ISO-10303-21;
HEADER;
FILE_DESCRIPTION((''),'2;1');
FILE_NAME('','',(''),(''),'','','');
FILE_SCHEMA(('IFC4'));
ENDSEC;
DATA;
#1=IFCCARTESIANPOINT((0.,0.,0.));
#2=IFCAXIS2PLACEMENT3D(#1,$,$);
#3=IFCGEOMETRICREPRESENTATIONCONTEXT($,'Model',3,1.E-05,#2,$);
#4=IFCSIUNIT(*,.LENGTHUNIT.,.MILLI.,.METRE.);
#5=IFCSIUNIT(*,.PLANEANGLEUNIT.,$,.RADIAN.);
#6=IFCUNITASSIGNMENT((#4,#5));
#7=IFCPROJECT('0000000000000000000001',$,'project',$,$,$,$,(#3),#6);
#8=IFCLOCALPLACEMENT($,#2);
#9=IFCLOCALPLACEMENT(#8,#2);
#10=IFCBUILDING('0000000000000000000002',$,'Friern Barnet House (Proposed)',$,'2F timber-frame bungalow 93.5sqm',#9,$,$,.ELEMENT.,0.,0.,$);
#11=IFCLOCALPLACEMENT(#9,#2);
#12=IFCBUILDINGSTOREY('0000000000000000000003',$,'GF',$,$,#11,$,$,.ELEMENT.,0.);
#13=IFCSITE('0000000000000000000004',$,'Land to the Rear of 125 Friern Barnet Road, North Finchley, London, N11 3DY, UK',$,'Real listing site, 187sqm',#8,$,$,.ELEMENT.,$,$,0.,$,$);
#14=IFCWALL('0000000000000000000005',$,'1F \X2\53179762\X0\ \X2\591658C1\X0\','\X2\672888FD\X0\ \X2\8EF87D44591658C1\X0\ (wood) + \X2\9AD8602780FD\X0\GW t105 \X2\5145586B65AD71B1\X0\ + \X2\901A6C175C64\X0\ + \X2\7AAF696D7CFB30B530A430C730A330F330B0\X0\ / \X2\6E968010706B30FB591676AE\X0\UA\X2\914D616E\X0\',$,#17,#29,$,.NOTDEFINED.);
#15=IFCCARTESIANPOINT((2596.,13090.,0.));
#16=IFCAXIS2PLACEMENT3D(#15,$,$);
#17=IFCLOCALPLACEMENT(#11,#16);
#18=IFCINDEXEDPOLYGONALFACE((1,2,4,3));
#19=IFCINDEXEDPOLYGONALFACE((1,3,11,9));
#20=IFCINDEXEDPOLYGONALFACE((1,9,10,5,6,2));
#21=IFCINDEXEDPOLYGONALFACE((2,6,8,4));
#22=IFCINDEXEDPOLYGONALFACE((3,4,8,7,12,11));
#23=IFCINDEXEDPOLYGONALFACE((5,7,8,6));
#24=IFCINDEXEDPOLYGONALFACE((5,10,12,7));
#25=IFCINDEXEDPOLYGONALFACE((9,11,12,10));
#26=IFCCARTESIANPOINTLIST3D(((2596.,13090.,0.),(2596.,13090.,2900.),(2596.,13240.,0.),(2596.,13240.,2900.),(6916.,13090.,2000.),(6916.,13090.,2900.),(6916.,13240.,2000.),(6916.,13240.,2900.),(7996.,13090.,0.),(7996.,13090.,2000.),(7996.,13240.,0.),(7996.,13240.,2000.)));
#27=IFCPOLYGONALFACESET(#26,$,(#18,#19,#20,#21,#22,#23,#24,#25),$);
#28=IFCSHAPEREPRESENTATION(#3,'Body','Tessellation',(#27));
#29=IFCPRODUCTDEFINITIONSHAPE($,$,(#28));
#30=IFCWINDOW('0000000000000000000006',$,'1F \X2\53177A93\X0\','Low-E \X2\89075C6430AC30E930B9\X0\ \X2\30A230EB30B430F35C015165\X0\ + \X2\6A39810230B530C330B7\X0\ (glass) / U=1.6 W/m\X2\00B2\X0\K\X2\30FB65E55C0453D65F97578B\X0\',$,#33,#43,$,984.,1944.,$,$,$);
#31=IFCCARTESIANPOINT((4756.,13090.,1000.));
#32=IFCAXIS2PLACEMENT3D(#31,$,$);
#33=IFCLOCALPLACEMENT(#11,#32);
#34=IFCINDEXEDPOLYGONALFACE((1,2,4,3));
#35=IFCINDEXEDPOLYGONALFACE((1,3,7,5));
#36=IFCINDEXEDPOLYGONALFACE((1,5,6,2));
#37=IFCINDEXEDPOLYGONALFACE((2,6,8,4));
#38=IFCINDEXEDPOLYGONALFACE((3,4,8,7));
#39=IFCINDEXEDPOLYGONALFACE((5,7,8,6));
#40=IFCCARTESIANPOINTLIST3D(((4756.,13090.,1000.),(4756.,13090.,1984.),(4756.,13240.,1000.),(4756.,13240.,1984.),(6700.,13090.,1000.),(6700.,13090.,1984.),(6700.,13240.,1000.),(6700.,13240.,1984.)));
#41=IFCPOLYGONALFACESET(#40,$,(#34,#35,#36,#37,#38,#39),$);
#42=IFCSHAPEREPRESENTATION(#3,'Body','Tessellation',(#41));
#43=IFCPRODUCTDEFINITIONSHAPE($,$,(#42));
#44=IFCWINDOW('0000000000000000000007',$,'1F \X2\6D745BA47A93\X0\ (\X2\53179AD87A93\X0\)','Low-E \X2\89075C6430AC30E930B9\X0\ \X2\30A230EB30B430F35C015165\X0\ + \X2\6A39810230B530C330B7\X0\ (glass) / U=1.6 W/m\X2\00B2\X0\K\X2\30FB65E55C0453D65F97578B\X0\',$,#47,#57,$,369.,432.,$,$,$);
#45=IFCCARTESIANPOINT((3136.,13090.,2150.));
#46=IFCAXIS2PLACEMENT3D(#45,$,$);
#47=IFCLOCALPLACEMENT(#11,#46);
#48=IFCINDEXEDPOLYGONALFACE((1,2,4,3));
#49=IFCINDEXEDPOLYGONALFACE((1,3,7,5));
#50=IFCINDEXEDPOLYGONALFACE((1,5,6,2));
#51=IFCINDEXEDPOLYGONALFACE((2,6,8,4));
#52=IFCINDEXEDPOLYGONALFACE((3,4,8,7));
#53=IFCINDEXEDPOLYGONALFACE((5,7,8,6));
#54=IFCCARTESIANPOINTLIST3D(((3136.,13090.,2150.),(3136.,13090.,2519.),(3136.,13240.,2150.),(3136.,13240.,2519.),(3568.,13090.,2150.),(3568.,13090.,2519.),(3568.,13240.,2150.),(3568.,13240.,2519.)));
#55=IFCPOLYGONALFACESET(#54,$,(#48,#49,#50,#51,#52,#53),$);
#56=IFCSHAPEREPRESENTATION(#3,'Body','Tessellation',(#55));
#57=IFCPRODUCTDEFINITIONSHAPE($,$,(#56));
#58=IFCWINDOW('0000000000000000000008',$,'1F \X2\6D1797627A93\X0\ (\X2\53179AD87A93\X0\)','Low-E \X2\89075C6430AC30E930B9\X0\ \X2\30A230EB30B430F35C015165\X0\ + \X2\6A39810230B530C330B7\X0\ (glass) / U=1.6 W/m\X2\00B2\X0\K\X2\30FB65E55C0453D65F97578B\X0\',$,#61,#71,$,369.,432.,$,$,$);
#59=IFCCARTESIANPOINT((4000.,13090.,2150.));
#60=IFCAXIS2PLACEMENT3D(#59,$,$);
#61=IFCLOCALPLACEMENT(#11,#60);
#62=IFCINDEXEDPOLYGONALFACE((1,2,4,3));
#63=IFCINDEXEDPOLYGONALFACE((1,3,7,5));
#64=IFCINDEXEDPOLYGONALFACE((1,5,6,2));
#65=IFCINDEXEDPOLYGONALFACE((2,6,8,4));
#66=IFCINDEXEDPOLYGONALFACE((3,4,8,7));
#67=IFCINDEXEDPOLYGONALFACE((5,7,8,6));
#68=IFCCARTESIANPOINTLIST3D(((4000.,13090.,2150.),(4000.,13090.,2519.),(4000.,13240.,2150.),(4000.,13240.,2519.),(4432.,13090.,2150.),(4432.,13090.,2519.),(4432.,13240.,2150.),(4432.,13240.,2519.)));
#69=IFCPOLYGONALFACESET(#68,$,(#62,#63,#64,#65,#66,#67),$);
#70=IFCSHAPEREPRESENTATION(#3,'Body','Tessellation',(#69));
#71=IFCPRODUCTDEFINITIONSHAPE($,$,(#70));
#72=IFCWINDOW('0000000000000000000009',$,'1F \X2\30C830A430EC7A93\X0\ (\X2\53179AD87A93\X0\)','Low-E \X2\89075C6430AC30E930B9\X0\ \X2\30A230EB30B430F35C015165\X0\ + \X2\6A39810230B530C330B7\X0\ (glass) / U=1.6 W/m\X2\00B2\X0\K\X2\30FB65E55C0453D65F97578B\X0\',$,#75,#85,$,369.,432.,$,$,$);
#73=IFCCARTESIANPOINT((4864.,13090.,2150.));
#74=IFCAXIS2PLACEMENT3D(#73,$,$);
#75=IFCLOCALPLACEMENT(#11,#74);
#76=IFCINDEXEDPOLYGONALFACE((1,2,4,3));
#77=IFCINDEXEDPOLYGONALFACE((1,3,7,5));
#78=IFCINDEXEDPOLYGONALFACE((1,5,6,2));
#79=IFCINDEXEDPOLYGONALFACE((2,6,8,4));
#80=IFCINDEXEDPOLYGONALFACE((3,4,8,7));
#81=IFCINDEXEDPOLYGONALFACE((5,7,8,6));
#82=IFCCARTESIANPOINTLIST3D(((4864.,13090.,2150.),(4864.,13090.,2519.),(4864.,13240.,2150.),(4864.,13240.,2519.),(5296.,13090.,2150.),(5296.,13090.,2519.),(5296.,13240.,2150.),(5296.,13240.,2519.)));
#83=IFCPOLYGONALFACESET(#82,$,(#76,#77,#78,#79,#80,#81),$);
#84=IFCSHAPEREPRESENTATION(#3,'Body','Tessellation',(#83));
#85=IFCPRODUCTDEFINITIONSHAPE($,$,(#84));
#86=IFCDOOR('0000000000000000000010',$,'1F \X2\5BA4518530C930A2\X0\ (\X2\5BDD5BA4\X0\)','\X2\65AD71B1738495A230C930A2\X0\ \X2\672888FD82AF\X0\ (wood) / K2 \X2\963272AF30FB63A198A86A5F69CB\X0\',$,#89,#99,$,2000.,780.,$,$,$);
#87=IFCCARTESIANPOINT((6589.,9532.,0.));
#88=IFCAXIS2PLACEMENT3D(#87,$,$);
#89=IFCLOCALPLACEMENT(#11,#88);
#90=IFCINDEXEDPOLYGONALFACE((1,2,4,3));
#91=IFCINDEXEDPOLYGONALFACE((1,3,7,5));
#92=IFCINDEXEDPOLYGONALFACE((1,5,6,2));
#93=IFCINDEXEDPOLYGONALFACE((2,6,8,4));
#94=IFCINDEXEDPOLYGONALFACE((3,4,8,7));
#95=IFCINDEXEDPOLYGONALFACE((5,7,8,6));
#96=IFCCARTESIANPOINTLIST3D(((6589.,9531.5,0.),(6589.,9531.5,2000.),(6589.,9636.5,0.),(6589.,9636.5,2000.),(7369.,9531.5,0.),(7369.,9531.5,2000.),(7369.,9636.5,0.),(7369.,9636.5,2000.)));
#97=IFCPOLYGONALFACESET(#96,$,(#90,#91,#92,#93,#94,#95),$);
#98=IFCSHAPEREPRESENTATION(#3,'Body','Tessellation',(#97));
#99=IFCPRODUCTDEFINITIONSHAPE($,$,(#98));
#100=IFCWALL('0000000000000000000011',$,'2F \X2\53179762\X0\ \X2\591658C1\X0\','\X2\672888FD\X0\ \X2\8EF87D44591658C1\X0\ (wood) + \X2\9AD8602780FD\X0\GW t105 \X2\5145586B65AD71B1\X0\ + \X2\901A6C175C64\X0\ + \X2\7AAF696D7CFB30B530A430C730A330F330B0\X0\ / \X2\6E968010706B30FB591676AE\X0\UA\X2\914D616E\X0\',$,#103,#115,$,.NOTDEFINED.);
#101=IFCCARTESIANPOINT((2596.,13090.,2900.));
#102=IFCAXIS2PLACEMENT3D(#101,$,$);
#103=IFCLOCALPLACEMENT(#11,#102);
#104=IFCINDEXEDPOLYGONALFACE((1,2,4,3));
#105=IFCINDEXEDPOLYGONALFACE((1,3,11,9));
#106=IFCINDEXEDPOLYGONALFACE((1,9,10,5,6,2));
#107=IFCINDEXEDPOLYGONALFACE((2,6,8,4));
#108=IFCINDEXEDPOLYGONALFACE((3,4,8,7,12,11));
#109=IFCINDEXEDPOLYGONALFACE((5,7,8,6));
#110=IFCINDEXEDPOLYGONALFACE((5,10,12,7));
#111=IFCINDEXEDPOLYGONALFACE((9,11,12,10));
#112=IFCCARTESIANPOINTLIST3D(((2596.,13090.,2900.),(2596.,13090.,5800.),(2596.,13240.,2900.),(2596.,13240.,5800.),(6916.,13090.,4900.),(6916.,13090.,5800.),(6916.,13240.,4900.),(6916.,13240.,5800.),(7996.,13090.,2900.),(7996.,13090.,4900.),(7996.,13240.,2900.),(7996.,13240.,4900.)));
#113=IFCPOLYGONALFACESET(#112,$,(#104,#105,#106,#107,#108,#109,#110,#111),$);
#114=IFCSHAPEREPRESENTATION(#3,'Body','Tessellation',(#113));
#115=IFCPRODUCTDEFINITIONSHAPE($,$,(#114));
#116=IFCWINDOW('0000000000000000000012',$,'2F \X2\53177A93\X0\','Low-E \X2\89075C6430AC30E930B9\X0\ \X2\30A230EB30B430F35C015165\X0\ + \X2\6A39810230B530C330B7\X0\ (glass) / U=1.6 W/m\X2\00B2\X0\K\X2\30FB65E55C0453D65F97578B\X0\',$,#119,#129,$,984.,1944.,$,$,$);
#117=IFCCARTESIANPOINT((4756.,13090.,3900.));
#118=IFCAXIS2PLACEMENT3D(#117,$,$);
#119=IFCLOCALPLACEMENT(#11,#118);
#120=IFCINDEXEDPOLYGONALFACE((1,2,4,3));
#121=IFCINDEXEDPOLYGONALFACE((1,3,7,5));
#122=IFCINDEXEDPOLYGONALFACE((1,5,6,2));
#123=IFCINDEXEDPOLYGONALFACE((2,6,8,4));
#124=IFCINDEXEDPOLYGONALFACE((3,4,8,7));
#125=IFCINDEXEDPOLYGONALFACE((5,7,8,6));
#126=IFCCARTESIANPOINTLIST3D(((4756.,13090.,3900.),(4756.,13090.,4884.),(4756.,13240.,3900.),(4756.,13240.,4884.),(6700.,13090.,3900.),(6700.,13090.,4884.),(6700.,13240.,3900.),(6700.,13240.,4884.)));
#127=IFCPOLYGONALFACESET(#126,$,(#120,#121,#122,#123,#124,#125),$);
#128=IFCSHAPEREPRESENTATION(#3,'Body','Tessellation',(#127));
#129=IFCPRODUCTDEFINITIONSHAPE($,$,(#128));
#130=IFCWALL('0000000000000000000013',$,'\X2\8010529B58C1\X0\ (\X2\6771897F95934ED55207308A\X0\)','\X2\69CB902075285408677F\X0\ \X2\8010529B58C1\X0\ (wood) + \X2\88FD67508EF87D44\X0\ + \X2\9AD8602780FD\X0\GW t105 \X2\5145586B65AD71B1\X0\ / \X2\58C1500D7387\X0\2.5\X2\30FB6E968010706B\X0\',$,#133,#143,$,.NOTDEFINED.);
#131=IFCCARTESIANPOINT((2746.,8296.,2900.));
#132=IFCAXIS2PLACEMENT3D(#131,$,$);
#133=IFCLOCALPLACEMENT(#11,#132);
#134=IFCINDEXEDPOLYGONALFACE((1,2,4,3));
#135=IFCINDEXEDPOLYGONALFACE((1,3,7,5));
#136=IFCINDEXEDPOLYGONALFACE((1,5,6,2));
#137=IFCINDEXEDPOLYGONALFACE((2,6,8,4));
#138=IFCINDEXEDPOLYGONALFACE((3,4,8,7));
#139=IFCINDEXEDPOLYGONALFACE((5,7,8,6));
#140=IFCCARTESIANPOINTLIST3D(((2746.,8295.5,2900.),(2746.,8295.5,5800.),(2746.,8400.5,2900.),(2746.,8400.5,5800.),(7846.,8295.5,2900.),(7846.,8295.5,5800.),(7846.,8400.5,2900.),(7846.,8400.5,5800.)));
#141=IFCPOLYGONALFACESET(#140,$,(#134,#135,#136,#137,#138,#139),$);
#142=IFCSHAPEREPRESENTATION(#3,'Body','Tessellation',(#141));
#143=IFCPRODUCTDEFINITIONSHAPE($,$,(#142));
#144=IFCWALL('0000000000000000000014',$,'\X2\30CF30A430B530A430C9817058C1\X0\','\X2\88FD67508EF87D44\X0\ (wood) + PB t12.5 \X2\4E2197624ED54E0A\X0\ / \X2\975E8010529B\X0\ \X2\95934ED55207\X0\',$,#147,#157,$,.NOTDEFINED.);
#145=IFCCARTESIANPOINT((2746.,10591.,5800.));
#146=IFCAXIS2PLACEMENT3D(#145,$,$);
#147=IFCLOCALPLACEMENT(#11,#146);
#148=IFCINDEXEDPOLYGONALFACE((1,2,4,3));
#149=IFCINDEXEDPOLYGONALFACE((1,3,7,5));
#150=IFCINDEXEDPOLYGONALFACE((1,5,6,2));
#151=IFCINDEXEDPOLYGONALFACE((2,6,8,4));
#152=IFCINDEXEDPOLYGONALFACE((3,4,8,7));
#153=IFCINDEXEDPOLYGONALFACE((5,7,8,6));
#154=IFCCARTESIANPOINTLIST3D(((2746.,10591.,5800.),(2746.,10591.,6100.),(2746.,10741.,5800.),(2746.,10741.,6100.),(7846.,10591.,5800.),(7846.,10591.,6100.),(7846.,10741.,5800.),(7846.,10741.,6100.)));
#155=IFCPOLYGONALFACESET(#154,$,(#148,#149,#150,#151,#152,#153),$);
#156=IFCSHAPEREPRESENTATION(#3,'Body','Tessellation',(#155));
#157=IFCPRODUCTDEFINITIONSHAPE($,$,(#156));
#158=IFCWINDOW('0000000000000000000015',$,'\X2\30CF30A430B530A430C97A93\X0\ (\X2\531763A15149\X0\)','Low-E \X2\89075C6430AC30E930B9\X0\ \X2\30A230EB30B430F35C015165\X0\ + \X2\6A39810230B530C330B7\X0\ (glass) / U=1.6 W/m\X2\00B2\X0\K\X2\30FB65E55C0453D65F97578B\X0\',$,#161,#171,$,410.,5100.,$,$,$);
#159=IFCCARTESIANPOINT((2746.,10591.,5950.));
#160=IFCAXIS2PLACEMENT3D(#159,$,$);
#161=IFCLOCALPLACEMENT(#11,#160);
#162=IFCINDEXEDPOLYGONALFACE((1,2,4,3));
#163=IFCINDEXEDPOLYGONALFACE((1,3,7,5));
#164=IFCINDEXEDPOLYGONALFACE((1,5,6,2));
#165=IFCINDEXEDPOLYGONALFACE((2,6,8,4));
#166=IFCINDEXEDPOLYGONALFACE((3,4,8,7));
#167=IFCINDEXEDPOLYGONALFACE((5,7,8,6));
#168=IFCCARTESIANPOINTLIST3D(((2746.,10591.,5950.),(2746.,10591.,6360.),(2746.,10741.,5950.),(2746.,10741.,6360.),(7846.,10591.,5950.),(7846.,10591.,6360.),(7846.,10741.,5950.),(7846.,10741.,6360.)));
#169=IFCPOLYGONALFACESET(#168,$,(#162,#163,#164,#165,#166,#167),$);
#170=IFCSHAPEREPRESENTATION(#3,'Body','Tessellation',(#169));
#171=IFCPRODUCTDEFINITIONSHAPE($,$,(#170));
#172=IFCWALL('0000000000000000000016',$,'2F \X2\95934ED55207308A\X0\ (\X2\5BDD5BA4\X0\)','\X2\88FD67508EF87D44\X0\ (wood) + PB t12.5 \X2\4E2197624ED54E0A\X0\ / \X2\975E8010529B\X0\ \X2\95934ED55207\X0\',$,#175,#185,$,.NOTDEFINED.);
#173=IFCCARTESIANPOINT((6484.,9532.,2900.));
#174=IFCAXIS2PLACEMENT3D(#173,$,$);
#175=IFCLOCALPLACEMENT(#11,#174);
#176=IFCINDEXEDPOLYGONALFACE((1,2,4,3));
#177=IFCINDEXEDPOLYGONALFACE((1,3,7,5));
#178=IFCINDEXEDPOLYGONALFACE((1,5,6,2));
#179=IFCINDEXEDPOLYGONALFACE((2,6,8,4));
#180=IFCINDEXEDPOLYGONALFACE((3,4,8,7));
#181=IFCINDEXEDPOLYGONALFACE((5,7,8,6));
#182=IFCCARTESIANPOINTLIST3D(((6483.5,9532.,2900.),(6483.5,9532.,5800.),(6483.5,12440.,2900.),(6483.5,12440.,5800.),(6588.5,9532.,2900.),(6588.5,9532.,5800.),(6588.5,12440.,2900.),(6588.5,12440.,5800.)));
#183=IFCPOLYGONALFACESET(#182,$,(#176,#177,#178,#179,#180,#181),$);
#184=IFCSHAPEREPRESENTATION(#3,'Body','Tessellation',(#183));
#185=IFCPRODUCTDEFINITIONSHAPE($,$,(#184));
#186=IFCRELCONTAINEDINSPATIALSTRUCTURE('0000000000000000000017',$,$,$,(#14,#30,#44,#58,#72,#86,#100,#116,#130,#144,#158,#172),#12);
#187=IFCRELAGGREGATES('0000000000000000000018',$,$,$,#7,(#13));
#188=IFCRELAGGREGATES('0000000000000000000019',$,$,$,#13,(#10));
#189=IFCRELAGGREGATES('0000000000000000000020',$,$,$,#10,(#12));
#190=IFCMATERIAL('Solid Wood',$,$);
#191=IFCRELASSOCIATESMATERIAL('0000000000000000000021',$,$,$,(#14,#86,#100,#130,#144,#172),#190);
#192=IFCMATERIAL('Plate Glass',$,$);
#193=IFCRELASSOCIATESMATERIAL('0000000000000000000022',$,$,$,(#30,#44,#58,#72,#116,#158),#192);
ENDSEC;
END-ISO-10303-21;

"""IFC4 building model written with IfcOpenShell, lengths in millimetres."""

from ifc_helpers import new_model, si_unit, frame, frame_2d, origin, place, context, project, spatial, rectangle, extrude, material, element, fill, save


model = new_model("IFC4")

# Units and contexts
model_context = context("Model", 3, precision=1e-05, world=origin())
ifc_project = project(units=[si_unit("LENGTHUNIT", "METRE", prefix="MILLI"), si_unit("PLANEANGLEUNIT", "RADIAN")], contexts=[model_context])

# Site, building, storey
site_placement = place(None, origin())
site = spatial("IfcSite", under=ifc_project, at=site_placement, Name="Land to the Rear of 125 Friern Barnet Road, North Finchley, London, N11 3DY, UK", ObjectType="Real listing site, 187sqm", CompositionType="ELEMENT", RefElevation=0.0)
building_placement = place(site_placement, origin())
building = spatial("IfcBuilding", under=site, at=building_placement, Name="Friern Barnet House (Proposed)", ObjectType="2F timber-frame bungalow 93.5sqm", CompositionType="ELEMENT", ElevationOfRefHeight=0.0, ElevationOfTerrain=0.0)
storey_placement = place(building_placement, origin())
storey = spatial("IfcBuildingStorey", under=building, at=storey_placement, Name="GF", CompositionType="ELEMENT", Elevation=0.0)

# Wall, openings, windows
ifc_material_1 = material(Name="Solid Wood")
wall_1_placement = place(storey_placement, frame((2596.0, 13090.0, 0.0)))
wall_1 = element("IfcWall", 1, at=wall_1_placement, inside=storey, material=ifc_material_1, Name="1F 北面 外壁", Description="木製 軸組外壁 (wood) + 高性能GW t105 充填断熱 + 通気層 + 窯業系サイディング / 準耐火・外皮UA配慮", PredefinedType="NOTDEFINED", context=model_context, shape_type="SweptSolid", body=[
    extrude(rectangle(XDim=5400.0, YDim=150.0, at=frame_2d((2700.0, 75.0))), frame((2596.0, 13090.0, 0.0)), (0.0, 0.0, 1.0), 2900.0),
])
opening_1_placement = place(storey_placement, frame((4756.0, 13090.0, 1000.0)))
opening_1 = element("IfcOpeningElement", 2, at=opening_1_placement, cuts=wall_1, PredefinedType="NOTDEFINED", context=model_context, shape_type="SweptSolid", body=[
    extrude(rectangle(XDim=1944.0, YDim=150.0, at=frame_2d((972.0, 75.0))), frame((4756.0, 13090.0, 1000.0)), (0.0, 0.0, 1.0), 984.0),
])
opening_2_placement = place(storey_placement, frame((3136.0, 13090.0, 2150.0)))
opening_2 = element("IfcOpeningElement", 3, at=opening_2_placement, cuts=wall_1, PredefinedType="NOTDEFINED", context=model_context, shape_type="SweptSolid", body=[
    extrude(rectangle(XDim=432.0, YDim=150.0, at=frame_2d((216.0, 75.0))), frame((3136.0, 13090.0, 2150.0)), (0.0, 0.0, 1.0), 369.0),
])
opening_3_placement = place(storey_placement, frame((4000.0, 13090.0, 2150.0)))
opening_3 = element("IfcOpeningElement", 4, at=opening_3_placement, cuts=wall_1, PredefinedType="NOTDEFINED", context=model_context, shape_type="SweptSolid", body=[
    extrude(rectangle(XDim=432.0, YDim=150.0, at=frame_2d((216.0, 75.0))), frame((4000.0, 13090.0, 2150.0)), (0.0, 0.0, 1.0), 369.0),
])
opening_4_placement = place(storey_placement, frame((4864.0, 13090.0, 2150.0)))
opening_4 = element("IfcOpeningElement", 5, at=opening_4_placement, cuts=wall_1, PredefinedType="NOTDEFINED", context=model_context, shape_type="SweptSolid", body=[
    extrude(rectangle(XDim=432.0, YDim=150.0, at=frame_2d((216.0, 75.0))), frame((4864.0, 13090.0, 2150.0)), (0.0, 0.0, 1.0), 369.0),
])
ifc_material_2 = material(Name="Plate Glass")
window_1_placement = place(storey_placement, frame((4756.0, 13090.0, 1000.0)))
window_1 = element("IfcWindow", 6, at=window_1_placement, inside=storey, material=ifc_material_2, Name="1F 北窓", Description="Low-E 複層ガラス アルゴン封入 + 樹脂サッシ (glass) / U=1.6 W/m²K・日射取得型", OverallHeight=984.0, OverallWidth=1944.0, context=model_context, shape_type="SweptSolid", body=[
    extrude(rectangle(XDim=1944.0, YDim=150.0, at=frame_2d((972.0, 75.0))), frame((4756.0, 13090.0, 1000.0)), (0.0, 0.0, 1.0), 984.0),
])
fill(opening_1, window_1)
window_2_placement = place(storey_placement, frame((3136.0, 13090.0, 2150.0)))
window_2 = element("IfcWindow", 7, at=window_2_placement, inside=storey, material=ifc_material_2, Name="1F 浴室窓 (北高窓)", Description="Low-E 複層ガラス アルゴン封入 + 樹脂サッシ (glass) / U=1.6 W/m²K・日射取得型", OverallHeight=369.0, OverallWidth=432.0, context=model_context, shape_type="SweptSolid", body=[
    extrude(rectangle(XDim=432.0, YDim=150.0, at=frame_2d((216.0, 75.0))), frame((3136.0, 13090.0, 2150.0)), (0.0, 0.0, 1.0), 369.0),
])
fill(opening_2, window_2)
window_3_placement = place(storey_placement, frame((4000.0, 13090.0, 2150.0)))
window_3 = element("IfcWindow", 8, at=window_3_placement, inside=storey, material=ifc_material_2, Name="1F 洗面窓 (北高窓)", Description="Low-E 複層ガラス アルゴン封入 + 樹脂サッシ (glass) / U=1.6 W/m²K・日射取得型", OverallHeight=369.0, OverallWidth=432.0, context=model_context, shape_type="SweptSolid", body=[
    extrude(rectangle(XDim=432.0, YDim=150.0, at=frame_2d((216.0, 75.0))), frame((4000.0, 13090.0, 2150.0)), (0.0, 0.0, 1.0), 369.0),
])
fill(opening_3, window_3)
window_4_placement = place(storey_placement, frame((4864.0, 13090.0, 2150.0)))
window_4 = element("IfcWindow", 9, at=window_4_placement, inside=storey, material=ifc_material_2, Name="1F トイレ窓 (北高窓)", Description="Low-E 複層ガラス アルゴン封入 + 樹脂サッシ (glass) / U=1.6 W/m²K・日射取得型", OverallHeight=369.0, OverallWidth=432.0, context=model_context, shape_type="SweptSolid", body=[
    extrude(rectangle(XDim=432.0, YDim=150.0, at=frame_2d((216.0, 75.0))), frame((4864.0, 13090.0, 2150.0)), (0.0, 0.0, 1.0), 369.0),
])
fill(opening_4, window_4)

# Door
door_1_placement = place(storey_placement, frame((6589.0, 9532.0, 0.0)))
element("IfcDoor", 10, at=door_1_placement, inside=storey, material=ifc_material_1, Name="1F 室内ドア (寝室)", Description="断熱玄関ドア 木製芯 (wood) / K2 防犯・採風機構", OverallHeight=2000.0, OverallWidth=780.0, context=model_context, shape_type="SweptSolid", body=[
    extrude(rectangle(XDim=780.0, YDim=105.0, at=frame_2d((390.0, 52.0))), frame((6589.0, 9532.0, 0.0)), (0.0, 0.0, 1.0), 2000.0),
])

# Wall, opening, window
wall_2_placement = place(storey_placement, frame((2596.0, 13090.0, 2900.0)))
wall_2 = element("IfcWall", 11, at=wall_2_placement, inside=storey, material=ifc_material_1, Name="2F 北面 外壁", Description="木製 軸組外壁 (wood) + 高性能GW t105 充填断熱 + 通気層 + 窯業系サイディング / 準耐火・外皮UA配慮", PredefinedType="NOTDEFINED", context=model_context, shape_type="SweptSolid", body=[
    extrude(rectangle(XDim=5400.0, YDim=150.0, at=frame_2d((2700.0, 75.0))), frame((2596.0, 13090.0, 2900.0)), (0.0, 0.0, 1.0), 2900.0),
])
opening_5_placement = place(storey_placement, frame((4756.0, 13090.0, 3900.0)))
opening_5 = element("IfcOpeningElement", 12, at=opening_5_placement, cuts=wall_2, PredefinedType="NOTDEFINED", context=model_context, shape_type="SweptSolid", body=[
    extrude(rectangle(XDim=1944.0, YDim=150.0, at=frame_2d((972.0, 75.0))), frame((4756.0, 13090.0, 3900.0)), (0.0, 0.0, 1.0), 984.0),
])
window_5_placement = place(storey_placement, frame((4756.0, 13090.0, 3900.0)))
window_5 = element("IfcWindow", 13, at=window_5_placement, inside=storey, material=ifc_material_2, Name="2F 北窓", Description="Low-E 複層ガラス アルゴン封入 + 樹脂サッシ (glass) / U=1.6 W/m²K・日射取得型", OverallHeight=984.0, OverallWidth=1944.0, context=model_context, shape_type="SweptSolid", body=[
    extrude(rectangle(XDim=1944.0, YDim=150.0, at=frame_2d((972.0, 75.0))), frame((4756.0, 13090.0, 3900.0)), (0.0, 0.0, 1.0), 984.0),
])
fill(opening_5, window_5)

# Wall
wall_3_placement = place(storey_placement, frame((2746.0, 8296.0, 2900.0)))
element("IfcWall", 14, at=wall_3_placement, inside=storey, material=ifc_material_1, Name="耐力壁 (東西間仕切り)", Description="構造用合板 耐力壁 (wood) + 製材軸組 + 高性能GW t105 充填断熱 / 壁倍率2.5・準耐火", PredefinedType="NOTDEFINED", context=model_context, shape_type="SweptSolid", body=[
    extrude(rectangle(XDim=5100.0, YDim=105.0, at=frame_2d((2550.0, 52.0))), frame((2746.0, 8296.0, 2900.0)), (0.0, 0.0, 1.0), 2900.0),
])

# Wall, opening, window
wall_4_placement = place(storey_placement, frame((2746.0, 10591.0, 5800.0)))
wall_4 = element("IfcWall", 15, at=wall_4_placement, inside=storey, material=ifc_material_1, Name="ハイサイド腰壁", Description="製材軸組 (wood) + PB t12.5 両面仕上 / 非耐力 間仕切", PredefinedType="NOTDEFINED", context=model_context, shape_type="SweptSolid", body=[
    extrude(rectangle(XDim=5100.0, YDim=150.0, at=frame_2d((2550.0, 75.0))), frame((2746.0, 10591.0, 5800.0)), (0.0, 0.0, 1.0), 700.0),
])
opening_6_placement = place(storey_placement, frame((2746.0, 10591.0, 5950.0)))
opening_6 = element("IfcOpeningElement", 16, at=opening_6_placement, cuts=wall_4, PredefinedType="NOTDEFINED", context=model_context, shape_type="SweptSolid", body=[
    extrude(rectangle(XDim=5100.0, YDim=150.0, at=frame_2d((2550.0, 75.0))), frame((2746.0, 10591.0, 5950.0)), (0.0, 0.0, 1.0), 410.0),
])
window_6_placement = place(storey_placement, frame((2746.0, 10591.0, 5950.0)))
window_6 = element("IfcWindow", 17, at=window_6_placement, inside=storey, material=ifc_material_2, Name="ハイサイド窓 (北採光)", Description="Low-E 複層ガラス アルゴン封入 + 樹脂サッシ (glass) / U=1.6 W/m²K・日射取得型", OverallHeight=410.0, OverallWidth=5100.0, context=model_context, shape_type="SweptSolid", body=[
    extrude(rectangle(XDim=5100.0, YDim=150.0, at=frame_2d((2550.0, 75.0))), frame((2746.0, 10591.0, 5950.0)), (0.0, 0.0, 1.0), 410.0),
])
fill(opening_6, window_6)

# Wall
wall_5_placement = place(storey_placement, frame((6484.0, 9532.0, 2900.0)))
element("IfcWall", 18, at=wall_5_placement, inside=storey, material=ifc_material_1, Name="2F 間仕切り (寝室)", Description="製材軸組 (wood) + PB t12.5 両面仕上 / 非耐力 間仕切", PredefinedType="NOTDEFINED", context=model_context, shape_type="SweptSolid", body=[
    extrude(rectangle(XDim=105.0, YDim=2908.0, at=frame_2d((52.0, 1454.0))), frame((6484.0, 9532.0, 2900.0)), (0.0, 0.0, 1.0), 2900.0),
])

save(model, "model.ifc")
